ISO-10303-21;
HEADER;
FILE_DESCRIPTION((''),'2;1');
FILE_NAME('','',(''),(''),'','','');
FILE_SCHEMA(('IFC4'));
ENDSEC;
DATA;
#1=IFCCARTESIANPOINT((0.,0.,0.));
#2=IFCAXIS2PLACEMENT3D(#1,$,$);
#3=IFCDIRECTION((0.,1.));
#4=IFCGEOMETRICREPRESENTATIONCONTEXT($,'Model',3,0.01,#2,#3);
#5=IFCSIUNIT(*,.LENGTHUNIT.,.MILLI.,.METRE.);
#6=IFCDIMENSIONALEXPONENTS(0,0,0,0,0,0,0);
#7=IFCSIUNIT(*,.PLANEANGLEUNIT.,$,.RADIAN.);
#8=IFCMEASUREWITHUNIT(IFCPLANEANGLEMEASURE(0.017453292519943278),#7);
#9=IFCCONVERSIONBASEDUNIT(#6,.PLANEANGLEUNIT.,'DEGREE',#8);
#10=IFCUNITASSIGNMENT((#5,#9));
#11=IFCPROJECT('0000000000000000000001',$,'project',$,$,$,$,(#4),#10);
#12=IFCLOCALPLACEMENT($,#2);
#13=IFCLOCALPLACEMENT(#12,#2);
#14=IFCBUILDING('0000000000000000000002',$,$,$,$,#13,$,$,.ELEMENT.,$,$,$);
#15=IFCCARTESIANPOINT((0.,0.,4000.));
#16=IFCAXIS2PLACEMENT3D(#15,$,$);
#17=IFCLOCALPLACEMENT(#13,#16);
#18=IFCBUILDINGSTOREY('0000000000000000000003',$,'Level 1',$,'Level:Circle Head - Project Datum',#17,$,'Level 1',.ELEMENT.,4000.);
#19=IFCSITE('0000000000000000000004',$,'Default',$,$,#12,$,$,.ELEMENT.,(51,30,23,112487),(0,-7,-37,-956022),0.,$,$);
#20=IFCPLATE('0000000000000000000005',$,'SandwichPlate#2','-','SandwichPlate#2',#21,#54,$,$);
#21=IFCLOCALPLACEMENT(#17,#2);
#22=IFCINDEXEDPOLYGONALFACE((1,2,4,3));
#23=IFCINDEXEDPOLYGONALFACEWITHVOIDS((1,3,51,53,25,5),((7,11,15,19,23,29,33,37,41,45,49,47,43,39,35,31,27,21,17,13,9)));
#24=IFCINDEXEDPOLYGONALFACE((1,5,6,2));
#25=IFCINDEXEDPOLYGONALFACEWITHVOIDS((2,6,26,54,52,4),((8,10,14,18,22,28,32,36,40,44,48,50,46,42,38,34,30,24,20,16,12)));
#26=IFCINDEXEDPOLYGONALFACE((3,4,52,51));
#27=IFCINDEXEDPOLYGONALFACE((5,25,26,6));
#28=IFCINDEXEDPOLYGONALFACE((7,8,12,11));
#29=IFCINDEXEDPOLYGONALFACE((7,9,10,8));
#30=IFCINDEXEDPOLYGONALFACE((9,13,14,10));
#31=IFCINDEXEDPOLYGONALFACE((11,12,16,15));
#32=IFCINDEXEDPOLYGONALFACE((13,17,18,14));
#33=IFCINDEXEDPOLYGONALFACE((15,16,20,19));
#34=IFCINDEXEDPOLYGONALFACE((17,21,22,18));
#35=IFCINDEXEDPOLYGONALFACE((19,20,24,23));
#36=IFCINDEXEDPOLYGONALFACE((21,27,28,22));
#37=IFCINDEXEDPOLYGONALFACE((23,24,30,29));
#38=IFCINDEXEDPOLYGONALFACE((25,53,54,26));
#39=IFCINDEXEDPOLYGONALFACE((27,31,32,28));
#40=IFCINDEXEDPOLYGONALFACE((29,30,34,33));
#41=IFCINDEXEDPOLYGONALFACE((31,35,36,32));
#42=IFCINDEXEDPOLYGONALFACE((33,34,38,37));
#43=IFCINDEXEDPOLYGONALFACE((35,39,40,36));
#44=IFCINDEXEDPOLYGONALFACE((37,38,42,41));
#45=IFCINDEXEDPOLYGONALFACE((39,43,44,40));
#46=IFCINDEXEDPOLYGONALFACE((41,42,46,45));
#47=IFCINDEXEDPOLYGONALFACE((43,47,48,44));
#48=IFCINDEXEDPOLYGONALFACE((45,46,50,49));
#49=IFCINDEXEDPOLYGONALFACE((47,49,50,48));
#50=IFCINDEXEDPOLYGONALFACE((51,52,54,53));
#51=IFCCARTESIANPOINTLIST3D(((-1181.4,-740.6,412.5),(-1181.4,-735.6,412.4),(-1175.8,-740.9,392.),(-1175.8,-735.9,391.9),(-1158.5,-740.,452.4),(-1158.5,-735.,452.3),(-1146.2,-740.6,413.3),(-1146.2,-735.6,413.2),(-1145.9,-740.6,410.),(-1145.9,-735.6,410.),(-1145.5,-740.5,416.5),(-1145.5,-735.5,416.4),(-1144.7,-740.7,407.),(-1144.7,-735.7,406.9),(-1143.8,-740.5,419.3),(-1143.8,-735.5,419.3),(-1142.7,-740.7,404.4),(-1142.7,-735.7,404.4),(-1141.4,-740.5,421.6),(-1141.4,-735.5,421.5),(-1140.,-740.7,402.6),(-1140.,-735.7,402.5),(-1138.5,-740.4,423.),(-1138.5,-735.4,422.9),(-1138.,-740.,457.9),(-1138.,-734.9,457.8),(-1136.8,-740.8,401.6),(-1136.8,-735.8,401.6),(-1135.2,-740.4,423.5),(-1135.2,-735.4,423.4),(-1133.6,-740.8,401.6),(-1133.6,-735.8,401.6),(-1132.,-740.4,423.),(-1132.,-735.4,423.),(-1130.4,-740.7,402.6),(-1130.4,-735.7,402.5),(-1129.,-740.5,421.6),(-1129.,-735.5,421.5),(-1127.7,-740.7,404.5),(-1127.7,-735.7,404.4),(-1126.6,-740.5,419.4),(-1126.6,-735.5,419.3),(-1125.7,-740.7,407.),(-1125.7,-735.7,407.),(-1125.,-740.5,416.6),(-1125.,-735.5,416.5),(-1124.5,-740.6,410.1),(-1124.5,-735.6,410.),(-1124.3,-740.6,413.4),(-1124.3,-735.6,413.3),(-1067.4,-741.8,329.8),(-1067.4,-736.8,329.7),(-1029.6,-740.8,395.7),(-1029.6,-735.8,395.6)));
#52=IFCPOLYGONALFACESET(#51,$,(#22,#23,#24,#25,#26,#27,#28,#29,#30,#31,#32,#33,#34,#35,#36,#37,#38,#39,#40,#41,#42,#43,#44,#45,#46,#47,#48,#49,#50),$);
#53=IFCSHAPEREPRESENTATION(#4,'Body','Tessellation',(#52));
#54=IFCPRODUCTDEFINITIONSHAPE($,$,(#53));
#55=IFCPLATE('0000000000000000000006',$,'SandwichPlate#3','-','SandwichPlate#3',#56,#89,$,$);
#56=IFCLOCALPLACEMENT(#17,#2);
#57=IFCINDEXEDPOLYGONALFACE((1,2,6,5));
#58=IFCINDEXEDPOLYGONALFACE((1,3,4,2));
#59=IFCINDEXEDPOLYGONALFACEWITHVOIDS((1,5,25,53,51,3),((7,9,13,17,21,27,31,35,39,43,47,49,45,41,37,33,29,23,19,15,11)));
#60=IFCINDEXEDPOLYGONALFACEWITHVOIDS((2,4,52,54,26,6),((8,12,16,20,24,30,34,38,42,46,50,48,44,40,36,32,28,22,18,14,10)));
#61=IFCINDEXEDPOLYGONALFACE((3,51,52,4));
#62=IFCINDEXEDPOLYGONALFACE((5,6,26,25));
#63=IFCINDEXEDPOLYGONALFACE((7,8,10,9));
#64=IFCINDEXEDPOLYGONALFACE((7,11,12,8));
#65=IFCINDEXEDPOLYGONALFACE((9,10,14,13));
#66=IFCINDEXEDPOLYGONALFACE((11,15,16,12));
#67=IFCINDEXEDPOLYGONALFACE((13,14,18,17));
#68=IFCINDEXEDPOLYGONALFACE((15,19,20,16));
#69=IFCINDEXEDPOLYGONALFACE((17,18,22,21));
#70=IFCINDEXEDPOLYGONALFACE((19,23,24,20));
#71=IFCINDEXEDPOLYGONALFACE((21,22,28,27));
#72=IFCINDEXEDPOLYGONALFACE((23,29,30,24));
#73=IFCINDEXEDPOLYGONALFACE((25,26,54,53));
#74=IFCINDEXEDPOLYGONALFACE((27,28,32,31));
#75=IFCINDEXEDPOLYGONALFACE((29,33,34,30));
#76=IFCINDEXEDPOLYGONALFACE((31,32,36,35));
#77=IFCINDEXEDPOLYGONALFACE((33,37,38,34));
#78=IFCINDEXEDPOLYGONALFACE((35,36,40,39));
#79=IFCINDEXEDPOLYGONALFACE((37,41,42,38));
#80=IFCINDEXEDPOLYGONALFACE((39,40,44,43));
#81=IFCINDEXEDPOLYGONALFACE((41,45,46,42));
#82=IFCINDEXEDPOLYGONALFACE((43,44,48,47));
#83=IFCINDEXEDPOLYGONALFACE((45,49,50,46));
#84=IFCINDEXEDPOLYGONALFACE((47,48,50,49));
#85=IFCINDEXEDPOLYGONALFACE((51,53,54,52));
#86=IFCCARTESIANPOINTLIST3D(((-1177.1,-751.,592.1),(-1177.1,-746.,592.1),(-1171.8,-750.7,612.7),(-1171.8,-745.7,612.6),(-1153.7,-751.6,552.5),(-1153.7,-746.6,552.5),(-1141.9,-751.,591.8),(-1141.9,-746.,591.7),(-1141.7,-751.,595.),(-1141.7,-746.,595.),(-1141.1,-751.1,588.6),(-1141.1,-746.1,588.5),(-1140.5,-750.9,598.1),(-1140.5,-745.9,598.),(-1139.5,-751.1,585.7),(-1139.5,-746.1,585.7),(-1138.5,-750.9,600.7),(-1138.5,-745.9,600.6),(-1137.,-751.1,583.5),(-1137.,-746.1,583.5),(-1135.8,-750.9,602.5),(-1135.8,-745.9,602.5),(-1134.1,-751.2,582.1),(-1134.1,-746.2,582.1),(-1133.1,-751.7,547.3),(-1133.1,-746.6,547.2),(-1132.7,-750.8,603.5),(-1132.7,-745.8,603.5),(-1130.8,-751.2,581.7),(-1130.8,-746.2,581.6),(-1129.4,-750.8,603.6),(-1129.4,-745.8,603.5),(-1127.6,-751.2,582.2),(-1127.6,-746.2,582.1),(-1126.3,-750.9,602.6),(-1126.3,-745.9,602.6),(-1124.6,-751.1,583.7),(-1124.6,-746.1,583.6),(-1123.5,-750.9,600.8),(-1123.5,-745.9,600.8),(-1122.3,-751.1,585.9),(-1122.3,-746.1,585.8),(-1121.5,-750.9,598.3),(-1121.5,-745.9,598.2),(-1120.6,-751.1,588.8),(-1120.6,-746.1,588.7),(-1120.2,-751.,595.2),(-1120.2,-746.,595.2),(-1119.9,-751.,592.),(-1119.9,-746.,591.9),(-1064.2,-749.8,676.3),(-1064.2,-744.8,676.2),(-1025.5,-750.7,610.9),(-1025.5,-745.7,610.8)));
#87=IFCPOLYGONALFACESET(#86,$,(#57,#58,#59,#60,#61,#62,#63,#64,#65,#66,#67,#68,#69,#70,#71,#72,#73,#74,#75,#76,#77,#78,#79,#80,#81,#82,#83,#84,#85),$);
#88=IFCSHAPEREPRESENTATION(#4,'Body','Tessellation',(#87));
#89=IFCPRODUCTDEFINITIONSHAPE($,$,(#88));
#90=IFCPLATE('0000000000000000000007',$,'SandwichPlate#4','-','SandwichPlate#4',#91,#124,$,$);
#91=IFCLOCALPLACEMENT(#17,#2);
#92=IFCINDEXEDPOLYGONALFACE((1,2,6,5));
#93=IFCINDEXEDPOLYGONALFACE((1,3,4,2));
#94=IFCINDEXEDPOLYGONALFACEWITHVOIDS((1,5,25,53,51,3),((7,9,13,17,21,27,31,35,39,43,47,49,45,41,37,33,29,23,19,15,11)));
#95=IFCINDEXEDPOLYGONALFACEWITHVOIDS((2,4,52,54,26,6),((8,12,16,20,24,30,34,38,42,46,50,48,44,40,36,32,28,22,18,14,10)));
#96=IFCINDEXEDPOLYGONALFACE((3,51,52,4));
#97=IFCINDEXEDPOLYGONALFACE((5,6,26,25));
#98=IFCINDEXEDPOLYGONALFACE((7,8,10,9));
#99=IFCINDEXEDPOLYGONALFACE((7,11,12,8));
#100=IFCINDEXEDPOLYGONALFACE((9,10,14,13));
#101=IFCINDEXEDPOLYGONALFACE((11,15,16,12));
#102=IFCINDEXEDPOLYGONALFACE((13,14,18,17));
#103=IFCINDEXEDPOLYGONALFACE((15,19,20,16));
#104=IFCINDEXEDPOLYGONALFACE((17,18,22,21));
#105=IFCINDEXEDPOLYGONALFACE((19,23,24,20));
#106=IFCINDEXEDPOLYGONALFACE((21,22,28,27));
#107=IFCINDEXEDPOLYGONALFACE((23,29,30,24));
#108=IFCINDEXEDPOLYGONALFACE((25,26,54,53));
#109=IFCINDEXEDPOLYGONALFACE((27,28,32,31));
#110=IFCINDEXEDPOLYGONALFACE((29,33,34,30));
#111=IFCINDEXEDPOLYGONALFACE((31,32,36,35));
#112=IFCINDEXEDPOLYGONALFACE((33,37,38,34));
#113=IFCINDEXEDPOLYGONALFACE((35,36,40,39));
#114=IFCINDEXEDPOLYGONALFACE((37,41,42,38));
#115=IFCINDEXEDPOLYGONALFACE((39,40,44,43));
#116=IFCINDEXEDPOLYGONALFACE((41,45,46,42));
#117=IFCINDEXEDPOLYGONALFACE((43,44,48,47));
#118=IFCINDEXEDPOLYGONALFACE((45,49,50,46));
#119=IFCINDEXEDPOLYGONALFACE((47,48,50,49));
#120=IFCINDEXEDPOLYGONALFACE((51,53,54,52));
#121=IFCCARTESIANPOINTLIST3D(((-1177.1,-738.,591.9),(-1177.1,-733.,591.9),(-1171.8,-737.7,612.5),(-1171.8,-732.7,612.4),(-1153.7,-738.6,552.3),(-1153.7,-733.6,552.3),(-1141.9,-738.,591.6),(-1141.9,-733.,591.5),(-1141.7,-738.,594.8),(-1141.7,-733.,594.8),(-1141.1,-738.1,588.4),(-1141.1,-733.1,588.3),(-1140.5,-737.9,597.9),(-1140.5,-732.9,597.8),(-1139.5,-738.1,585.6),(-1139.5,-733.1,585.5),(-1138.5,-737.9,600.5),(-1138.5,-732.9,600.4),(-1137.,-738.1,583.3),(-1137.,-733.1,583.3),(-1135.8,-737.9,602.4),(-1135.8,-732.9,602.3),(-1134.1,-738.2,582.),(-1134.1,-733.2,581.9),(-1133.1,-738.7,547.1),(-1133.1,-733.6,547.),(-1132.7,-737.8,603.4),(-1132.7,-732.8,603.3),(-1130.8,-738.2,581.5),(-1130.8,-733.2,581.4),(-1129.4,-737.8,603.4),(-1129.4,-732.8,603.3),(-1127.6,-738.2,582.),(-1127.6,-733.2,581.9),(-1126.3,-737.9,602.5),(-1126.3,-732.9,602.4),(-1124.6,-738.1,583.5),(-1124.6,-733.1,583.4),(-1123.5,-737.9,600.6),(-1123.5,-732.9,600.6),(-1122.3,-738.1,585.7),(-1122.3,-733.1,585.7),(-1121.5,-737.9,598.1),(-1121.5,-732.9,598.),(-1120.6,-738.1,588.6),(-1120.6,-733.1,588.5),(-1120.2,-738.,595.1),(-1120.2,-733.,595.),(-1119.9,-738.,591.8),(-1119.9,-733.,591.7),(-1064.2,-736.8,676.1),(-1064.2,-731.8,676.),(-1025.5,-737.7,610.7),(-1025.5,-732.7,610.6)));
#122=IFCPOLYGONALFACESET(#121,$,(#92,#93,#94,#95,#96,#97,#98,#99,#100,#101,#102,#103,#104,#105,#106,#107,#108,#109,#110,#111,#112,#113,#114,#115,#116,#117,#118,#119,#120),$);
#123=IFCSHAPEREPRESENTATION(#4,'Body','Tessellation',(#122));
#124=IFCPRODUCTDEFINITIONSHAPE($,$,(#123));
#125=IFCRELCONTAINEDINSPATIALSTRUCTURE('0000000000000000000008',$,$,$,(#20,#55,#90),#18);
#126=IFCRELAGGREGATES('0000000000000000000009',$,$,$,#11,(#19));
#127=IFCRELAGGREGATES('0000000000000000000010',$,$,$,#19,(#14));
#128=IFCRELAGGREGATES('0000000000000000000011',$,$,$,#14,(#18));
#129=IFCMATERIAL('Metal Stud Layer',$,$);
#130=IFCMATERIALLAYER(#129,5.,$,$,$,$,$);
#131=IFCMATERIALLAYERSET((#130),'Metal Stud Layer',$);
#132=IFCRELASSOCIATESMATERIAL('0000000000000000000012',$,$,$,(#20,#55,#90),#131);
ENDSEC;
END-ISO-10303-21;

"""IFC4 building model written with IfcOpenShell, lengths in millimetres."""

from ifc_helpers import new_model, entity, si_unit, converted_unit, direction, frame, origin, origin_with_axes, origin_2d_with_axis, place, context, project, spatial, polyline, circle, outline, extrude, material, layer, layer_set, element, save


model = new_model("IFC4")

# Units and contexts
model_context = context("Model", 3, precision=0.01, world=origin(), true_north=direction((0.0, 1.0)))
ifc_project = project(units=[si_unit("LENGTHUNIT", "METRE", prefix="MILLI"), converted_unit("PLANEANGLEUNIT", "DEGREE", entity("IfcPlaneAngleMeasure", 0.017453292519943278), si_unit("PLANEANGLEUNIT", "RADIAN"), dimensions=[0, 0, 0, 0, 0, 0, 0])], contexts=[model_context])

# Site, building, storey
site_placement = place(None, origin())
site = spatial("IfcSite", under=ifc_project, at=site_placement, Name="Default", CompositionType="ELEMENT", RefLatitude=(51, 30, 23, 112487), RefLongitude=(0, -7, -37, -956022), RefElevation=0.0)
building_placement = place(site_placement, origin())
building = spatial("IfcBuilding", under=site, at=building_placement, CompositionType="ELEMENT")
storey_placement = place(building_placement, frame((0.0, 0.0, 4000.0)))
storey = spatial("IfcBuildingStorey", under=building, at=storey_placement, Name="Level 1", ObjectType="Level:Circle Head - Project Datum", LongName="Level 1", CompositionType="ELEMENT", Elevation=4000.0)

# Plates, openings
ifc_material_1 = material(Name="Metal Stud Layer")
ifc_layer_1 = layer(ifc_material_1, 5.0)
ifc_layer_set_1 = layer_set([ifc_layer_1], Name="Metal Stud Layer")
plate_1_placement = place(storey_placement, frame((-1188.8, -740.8, 399.5), z_axis=(0.0, 0.999896, -0.014432), x_axis=(0.497964, 0.012516, 0.867107)))
plate_1 = element("IfcPlate", 1, at=plate_1_placement, inside=storey, material=ifc_layer_set_1, Name="SandwichPlate#2", Description="-", ObjectType="SandwichPlate#2", context=model_context, shape_type="SweptSolid", body=[
    extrude(outline(polyline([(0.0, 0.0), (76.0, 0.0), (76.0, 140.0), (0.0, 140.0), (0.0, 0.0)])), origin_with_axes(), (0.0, 0.0, 1.0), 5.0),
])
opening_1_placement = place(plate_1_placement, frame((0.0, 0.0, 0.0), z_axis=(0.0, 0.0, 1.0), x_axis=(1.0, 0.0, 0.0)))
element("IfcOpeningElement", 2, at=opening_1_placement, cuts=plate_1, ObjectType="Opening", context=model_context, shape_type="SweptSolid", body=[
    extrude(outline(polyline([(0.0, 0.0), (15.0, 0.0), (0.0, 15.0), (0.0, 0.0)])), origin(), (0.0, 0.0, 1.0), 5.0),
])
opening_2_placement = place(plate_1_placement, frame((0.0, 0.0, 0.0), z_axis=(0.0, 0.0, 1.0), x_axis=(1.0, 0.0, 0.0)))
element("IfcOpeningElement", 3, at=opening_2_placement, cuts=plate_1, ObjectType="Opening", context=model_context, shape_type="SweptSolid", body=[
    extrude(outline(polyline([(76.0, 0.0), (76.0, 15.0), (61.0, 0.0), (76.0, 0.0)])), origin(), (0.0, 0.0, 1.0), 5.0),
])
opening_3_placement = place(plate_1_placement, frame((38.0, 40.0, -0.5), z_axis=(0.0, 0.0, 1.0), x_axis=(0.0, 1.0, 0.0)))
element("IfcOpeningElement", 4, at=opening_3_placement, cuts=plate_1, ObjectType="Opening", context=model_context, shape_type="SweptSolid", body=[
    extrude(circle(Radius=11.0, at=origin_2d_with_axis()), origin(), (0.0, 0.0, 1.0), 6.0),
])
plate_2_placement = place(storey_placement, frame((-1146.0, -751.8, 539.6), z_axis=(0.0, 0.999896, -0.014432), x_axis=(-0.508911, 0.012424, 0.860729)))
plate_2 = element("IfcPlate", 5, at=plate_2_placement, inside=storey, material=ifc_layer_set_1, Name="SandwichPlate#3", Description="-", ObjectType="SandwichPlate#3", context=model_context, shape_type="SweptSolid", body=[
    extrude(outline(polyline([(0.0, 0.0), (76.0, 0.0), (76.0, 140.0), (0.0, 140.0), (0.0, 0.0)])), origin_with_axes(), (0.0, 0.0, 1.0), 5.0),
])
opening_4_placement = place(plate_2_placement, frame((0.0, 0.0, 0.0), z_axis=(0.0, 0.0, 1.0), x_axis=(1.0, 0.0, 0.0)))
element("IfcOpeningElement", 6, at=opening_4_placement, cuts=plate_2, ObjectType="Opening", context=model_context, shape_type="SweptSolid", body=[
    extrude(outline(polyline([(0.0, 0.0), (15.0, 0.0), (0.0, 15.0), (0.0, 0.0)])), origin(), (0.0, 0.0, 1.0), 5.0),
])
opening_5_placement = place(plate_2_placement, frame((0.0, 0.0, 0.0), z_axis=(0.0, 0.0, 1.0), x_axis=(1.0, 0.0, 0.0)))
element("IfcOpeningElement", 7, at=opening_5_placement, cuts=plate_2, ObjectType="Opening", context=model_context, shape_type="SweptSolid", body=[
    extrude(outline(polyline([(76.0, 0.0), (76.0, 15.0), (61.0, 0.0), (76.0, 0.0)])), origin(), (0.0, 0.0, 1.0), 5.0),
])
opening_6_placement = place(plate_2_placement, frame((38.0, 40.0, -0.5), z_axis=(0.0, 0.0, 1.0), x_axis=(0.0, 1.0, 0.0)))
element("IfcOpeningElement", 8, at=opening_6_placement, cuts=plate_2, ObjectType="Opening", context=model_context, shape_type="SweptSolid", body=[
    extrude(circle(Radius=11.0, at=origin_2d_with_axis()), origin(), (0.0, 0.0, 1.0), 6.0),
])
plate_3_placement = place(storey_placement, frame((-1146.0, -738.8, 539.4), z_axis=(0.0, 0.999896, -0.014432), x_axis=(-0.508911, 0.012424, 0.860729)))
plate_3 = element("IfcPlate", 9, at=plate_3_placement, inside=storey, material=ifc_layer_set_1, Name="SandwichPlate#4", Description="-", ObjectType="SandwichPlate#4", context=model_context, shape_type="SweptSolid", body=[
    extrude(outline(polyline([(0.0, 0.0), (76.0, 0.0), (76.0, 140.0), (0.0, 140.0), (0.0, 0.0)])), origin_with_axes(), (0.0, 0.0, 1.0), 5.0),
])
opening_7_placement = place(plate_3_placement, frame((0.0, 0.0, 0.0), z_axis=(0.0, 0.0, 1.0), x_axis=(1.0, 0.0, 0.0)))
element("IfcOpeningElement", 10, at=opening_7_placement, cuts=plate_3, ObjectType="Opening", context=model_context, shape_type="SweptSolid", body=[
    extrude(outline(polyline([(0.0, 0.0), (15.0, 0.0), (0.0, 15.0), (0.0, 0.0)])), origin(), (0.0, 0.0, 1.0), 5.0),
])
opening_8_placement = place(plate_3_placement, frame((0.0, 0.0, 0.0), z_axis=(0.0, 0.0, 1.0), x_axis=(1.0, 0.0, 0.0)))
element("IfcOpeningElement", 11, at=opening_8_placement, cuts=plate_3, ObjectType="Opening", context=model_context, shape_type="SweptSolid", body=[
    extrude(outline(polyline([(76.0, 0.0), (76.0, 15.0), (61.0, 0.0), (76.0, 0.0)])), origin(), (0.0, 0.0, 1.0), 5.0),
])
opening_9_placement = place(plate_3_placement, frame((38.0, 40.0, -0.5), z_axis=(0.0, 0.0, 1.0), x_axis=(0.0, 1.0, 0.0)))
element("IfcOpeningElement", 12, at=opening_9_placement, cuts=plate_3, ObjectType="Opening", context=model_context, shape_type="SweptSolid", body=[
    extrude(circle(Radius=11.0, at=origin_2d_with_axis()), origin(), (0.0, 0.0, 1.0), 6.0),
])

save(model, "model.ifc")
